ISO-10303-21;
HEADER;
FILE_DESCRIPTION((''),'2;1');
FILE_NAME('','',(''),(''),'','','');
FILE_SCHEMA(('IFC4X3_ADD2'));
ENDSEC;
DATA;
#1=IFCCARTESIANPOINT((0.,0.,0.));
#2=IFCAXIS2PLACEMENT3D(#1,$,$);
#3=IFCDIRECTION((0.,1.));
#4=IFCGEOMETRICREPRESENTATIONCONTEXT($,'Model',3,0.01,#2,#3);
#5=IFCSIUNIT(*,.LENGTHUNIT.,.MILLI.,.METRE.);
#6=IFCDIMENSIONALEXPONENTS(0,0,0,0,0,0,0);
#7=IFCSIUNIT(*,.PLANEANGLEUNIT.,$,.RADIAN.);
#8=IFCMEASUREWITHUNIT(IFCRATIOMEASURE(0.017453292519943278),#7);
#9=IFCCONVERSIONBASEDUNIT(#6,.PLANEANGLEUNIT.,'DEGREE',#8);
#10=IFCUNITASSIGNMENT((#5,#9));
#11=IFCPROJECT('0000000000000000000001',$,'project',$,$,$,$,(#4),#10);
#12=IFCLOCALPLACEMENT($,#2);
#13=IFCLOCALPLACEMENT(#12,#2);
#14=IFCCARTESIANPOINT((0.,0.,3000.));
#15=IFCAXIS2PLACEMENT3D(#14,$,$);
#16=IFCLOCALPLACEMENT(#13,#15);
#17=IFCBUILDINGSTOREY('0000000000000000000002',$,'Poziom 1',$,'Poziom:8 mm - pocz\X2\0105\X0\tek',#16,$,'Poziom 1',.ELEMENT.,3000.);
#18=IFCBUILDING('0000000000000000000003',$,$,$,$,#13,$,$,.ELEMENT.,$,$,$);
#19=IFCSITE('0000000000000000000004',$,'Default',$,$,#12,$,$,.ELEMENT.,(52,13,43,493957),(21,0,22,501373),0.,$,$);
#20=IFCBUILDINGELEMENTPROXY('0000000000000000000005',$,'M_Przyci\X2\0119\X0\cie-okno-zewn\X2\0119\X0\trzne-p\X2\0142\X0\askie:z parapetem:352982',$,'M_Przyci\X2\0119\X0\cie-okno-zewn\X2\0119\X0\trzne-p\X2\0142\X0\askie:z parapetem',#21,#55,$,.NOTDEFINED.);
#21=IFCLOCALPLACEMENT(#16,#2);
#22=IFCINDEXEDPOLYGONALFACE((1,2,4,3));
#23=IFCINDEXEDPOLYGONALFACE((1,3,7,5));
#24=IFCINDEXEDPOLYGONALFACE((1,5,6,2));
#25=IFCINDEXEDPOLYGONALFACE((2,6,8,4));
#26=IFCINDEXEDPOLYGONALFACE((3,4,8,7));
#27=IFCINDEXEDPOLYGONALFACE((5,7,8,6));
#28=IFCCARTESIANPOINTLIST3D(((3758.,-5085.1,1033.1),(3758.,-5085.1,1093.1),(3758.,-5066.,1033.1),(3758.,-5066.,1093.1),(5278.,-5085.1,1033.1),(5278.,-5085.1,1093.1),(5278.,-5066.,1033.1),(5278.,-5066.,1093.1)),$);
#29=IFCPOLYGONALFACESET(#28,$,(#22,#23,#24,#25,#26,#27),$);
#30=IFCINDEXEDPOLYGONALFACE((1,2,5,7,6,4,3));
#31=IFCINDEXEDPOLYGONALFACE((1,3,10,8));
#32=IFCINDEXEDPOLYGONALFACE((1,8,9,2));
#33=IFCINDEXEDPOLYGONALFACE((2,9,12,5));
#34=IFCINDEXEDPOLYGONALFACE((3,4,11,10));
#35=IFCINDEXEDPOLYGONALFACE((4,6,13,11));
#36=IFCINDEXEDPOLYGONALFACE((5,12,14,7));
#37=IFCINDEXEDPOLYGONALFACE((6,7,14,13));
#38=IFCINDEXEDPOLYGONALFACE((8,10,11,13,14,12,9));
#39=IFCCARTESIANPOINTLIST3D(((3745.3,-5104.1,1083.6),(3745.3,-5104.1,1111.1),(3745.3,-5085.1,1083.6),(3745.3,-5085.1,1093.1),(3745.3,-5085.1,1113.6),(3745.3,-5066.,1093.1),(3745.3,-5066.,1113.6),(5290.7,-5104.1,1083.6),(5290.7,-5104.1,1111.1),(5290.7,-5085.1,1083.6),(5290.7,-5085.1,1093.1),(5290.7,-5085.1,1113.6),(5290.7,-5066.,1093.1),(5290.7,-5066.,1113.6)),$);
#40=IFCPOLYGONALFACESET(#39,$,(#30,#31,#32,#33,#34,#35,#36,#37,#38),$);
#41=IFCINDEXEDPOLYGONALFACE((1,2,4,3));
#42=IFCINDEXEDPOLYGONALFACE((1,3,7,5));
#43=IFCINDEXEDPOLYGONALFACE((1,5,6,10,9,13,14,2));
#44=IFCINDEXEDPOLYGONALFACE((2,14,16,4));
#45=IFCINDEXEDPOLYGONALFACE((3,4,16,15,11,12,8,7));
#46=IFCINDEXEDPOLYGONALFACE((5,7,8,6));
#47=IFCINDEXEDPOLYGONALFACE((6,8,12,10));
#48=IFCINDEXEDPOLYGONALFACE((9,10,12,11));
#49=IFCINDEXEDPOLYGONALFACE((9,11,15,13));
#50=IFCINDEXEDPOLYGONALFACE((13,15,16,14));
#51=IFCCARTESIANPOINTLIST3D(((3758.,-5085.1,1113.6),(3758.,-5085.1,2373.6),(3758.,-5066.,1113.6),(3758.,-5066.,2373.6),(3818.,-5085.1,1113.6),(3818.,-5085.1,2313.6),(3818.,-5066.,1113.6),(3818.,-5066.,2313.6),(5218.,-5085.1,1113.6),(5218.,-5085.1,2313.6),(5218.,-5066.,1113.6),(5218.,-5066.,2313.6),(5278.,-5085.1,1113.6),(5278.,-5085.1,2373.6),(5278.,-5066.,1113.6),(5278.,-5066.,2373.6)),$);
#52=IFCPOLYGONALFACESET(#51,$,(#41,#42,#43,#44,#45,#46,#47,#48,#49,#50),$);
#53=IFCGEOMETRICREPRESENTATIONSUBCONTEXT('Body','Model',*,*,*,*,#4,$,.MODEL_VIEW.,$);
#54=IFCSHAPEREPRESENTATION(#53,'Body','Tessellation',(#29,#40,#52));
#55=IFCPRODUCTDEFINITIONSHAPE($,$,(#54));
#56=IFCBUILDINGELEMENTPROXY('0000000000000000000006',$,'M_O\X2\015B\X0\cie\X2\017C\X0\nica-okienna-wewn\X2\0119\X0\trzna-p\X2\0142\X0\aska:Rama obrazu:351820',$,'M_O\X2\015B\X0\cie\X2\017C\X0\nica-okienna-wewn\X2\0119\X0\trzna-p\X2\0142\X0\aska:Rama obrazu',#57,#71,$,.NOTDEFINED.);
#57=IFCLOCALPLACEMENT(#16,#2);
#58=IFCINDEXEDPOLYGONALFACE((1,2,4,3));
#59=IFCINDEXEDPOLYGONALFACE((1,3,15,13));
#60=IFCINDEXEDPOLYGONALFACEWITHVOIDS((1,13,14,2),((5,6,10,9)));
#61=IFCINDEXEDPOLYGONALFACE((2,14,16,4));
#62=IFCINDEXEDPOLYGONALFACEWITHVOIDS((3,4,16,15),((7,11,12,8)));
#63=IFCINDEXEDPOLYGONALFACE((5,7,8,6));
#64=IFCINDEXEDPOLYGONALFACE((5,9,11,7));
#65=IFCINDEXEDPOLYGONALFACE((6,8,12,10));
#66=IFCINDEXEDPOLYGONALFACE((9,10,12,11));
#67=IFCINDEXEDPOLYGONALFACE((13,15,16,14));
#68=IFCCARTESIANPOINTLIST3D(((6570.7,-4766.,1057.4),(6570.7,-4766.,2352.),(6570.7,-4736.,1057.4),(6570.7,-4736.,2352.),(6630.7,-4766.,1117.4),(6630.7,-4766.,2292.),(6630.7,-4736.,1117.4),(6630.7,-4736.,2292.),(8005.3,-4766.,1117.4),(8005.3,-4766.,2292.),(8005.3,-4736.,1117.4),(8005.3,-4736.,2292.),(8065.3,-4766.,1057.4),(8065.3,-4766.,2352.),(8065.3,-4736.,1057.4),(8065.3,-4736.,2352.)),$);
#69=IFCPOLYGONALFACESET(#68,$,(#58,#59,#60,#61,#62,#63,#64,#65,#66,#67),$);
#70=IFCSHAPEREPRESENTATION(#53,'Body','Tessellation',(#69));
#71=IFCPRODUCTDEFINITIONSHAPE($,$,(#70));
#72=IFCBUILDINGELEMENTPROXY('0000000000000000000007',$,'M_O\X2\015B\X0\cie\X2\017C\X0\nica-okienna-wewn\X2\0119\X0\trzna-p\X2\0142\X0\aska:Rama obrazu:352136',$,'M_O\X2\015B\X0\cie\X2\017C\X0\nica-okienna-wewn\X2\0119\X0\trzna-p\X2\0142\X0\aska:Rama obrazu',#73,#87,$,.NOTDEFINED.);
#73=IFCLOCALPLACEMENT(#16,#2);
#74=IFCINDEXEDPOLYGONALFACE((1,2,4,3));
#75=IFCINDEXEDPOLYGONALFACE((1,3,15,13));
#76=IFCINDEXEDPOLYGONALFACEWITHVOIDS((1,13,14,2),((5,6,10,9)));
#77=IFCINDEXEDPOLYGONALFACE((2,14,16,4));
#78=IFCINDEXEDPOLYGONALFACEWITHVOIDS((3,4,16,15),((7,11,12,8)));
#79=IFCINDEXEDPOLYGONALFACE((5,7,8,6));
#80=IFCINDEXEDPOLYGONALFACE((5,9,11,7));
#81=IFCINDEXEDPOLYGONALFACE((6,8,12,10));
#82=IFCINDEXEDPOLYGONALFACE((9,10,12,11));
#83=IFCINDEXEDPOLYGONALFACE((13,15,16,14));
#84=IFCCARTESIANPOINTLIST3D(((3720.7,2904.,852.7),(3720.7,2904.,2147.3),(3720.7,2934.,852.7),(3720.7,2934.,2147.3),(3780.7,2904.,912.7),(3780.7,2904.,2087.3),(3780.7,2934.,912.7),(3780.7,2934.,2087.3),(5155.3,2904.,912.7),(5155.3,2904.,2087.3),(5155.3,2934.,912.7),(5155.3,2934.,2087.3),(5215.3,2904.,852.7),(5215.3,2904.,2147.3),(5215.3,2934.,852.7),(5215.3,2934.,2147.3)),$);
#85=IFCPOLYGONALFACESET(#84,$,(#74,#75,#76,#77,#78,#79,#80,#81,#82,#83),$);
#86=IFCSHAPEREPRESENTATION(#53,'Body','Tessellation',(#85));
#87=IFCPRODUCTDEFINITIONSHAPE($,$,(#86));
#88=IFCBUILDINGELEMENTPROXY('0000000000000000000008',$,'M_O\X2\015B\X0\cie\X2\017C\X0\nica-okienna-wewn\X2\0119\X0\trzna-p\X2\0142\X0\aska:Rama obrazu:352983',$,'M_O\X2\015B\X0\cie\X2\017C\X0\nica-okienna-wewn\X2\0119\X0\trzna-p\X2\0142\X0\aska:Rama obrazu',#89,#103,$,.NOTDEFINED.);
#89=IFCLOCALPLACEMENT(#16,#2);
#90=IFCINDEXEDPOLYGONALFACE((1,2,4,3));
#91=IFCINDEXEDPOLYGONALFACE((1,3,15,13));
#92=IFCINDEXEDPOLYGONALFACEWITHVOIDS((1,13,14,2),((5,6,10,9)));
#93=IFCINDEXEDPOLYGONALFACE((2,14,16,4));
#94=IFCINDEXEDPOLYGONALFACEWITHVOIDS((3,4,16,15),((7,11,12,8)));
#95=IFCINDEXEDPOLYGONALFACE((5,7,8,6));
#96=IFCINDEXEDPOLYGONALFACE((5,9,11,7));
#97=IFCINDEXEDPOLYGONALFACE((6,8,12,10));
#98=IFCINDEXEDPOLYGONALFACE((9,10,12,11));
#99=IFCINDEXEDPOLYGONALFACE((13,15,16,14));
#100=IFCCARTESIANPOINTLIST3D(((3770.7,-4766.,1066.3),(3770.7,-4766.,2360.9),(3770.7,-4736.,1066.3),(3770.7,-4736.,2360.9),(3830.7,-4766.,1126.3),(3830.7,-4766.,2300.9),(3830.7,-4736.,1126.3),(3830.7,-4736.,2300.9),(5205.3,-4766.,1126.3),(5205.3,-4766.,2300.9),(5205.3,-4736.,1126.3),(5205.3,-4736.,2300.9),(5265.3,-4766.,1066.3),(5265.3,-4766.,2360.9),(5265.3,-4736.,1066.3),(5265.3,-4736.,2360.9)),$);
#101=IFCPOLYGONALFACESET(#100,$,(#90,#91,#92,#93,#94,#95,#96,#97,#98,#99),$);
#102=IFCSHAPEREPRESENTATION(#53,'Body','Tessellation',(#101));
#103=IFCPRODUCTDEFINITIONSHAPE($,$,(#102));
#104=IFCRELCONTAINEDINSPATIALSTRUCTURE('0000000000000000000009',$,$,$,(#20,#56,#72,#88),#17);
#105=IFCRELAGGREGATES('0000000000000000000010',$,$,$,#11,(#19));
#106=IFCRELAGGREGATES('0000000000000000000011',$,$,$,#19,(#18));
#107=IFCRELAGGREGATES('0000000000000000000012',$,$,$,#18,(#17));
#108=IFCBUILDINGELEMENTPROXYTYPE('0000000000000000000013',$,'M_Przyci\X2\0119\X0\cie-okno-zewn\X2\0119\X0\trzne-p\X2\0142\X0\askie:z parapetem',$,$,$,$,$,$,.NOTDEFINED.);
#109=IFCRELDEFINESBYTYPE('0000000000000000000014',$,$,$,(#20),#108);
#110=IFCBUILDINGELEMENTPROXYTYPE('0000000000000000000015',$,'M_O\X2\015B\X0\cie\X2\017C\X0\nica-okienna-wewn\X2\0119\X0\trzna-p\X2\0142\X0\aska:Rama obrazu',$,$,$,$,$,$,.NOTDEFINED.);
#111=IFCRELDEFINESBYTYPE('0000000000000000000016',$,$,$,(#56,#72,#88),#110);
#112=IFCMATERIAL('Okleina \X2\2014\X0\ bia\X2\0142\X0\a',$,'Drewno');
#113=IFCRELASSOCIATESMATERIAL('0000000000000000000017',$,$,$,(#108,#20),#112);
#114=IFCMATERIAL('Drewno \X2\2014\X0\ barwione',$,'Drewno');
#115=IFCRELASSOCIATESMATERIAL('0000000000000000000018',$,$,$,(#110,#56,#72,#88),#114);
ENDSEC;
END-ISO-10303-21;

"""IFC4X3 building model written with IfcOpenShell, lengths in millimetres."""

from ifc_helpers import new_model, entity, si_unit, converted_unit, direction, frame, frame_2d, origin, place, context, subcontext, project, spatial, polyline, rectangle, outline, extrude, source, transform, mapped, material, type_object, type_shapes, element, save


model = new_model("IFC4X3")

# Units and contexts
model_context = context("Model", 3, precision=0.01, world=origin(), true_north=direction((0.0, 1.0)))
body_context = subcontext(model_context, "Body", "Model", "MODEL_VIEW")
ifc_project = project(units=[si_unit("LENGTHUNIT", "METRE", prefix="MILLI"), converted_unit("PLANEANGLEUNIT", "DEGREE", entity("IfcRatioMeasure", 0.017453292519943278), si_unit("PLANEANGLEUNIT", "RADIAN"), dimensions=[0, 0, 0, 0, 0, 0, 0])], contexts=[model_context])

# Site, building, storey
site_placement = place(None, origin())
site = spatial("IfcSite", under=ifc_project, at=site_placement, Name="Default", CompositionType="ELEMENT", RefLatitude=(52, 13, 43, 493957), RefLongitude=(21, 0, 22, 501373), RefElevation=0.0)
building_placement = place(site_placement, origin())
building = spatial("IfcBuilding", under=site, at=building_placement, CompositionType="ELEMENT")
storey_placement = place(building_placement, frame((0.0, 0.0, 3000.0)))
storey = spatial("IfcBuildingStorey", under=building, at=storey_placement, Name="Poziom 1", ObjectType="Poziom:8 mm - początek", LongName="Poziom 1", CompositionType="ELEMENT", Elevation=3000.0)

# Building element proxies
ifc_material_1 = material(Name="Okleina — biała", Category="Drewno")
ifc_material_2 = material(Name="Drewno — barwione", Category="Drewno")
building_element_proxy_type_1 = type_object("IfcBuildingElementProxyType", Name="M_Przycięcie-okno-zewnętrzne-płaskie:z parapetem", PredefinedType="NOTDEFINED", material=ifc_material_1)
shared_shape_1 = source(origin(), body_context, "Body", "SweptSolid", [
    extrude(rectangle(XDim=1520.0, YDim=60.0, at=frame_2d((0.0, 0.0), x_axis=(1.0, 0.0))), frame((0.0, -1250.4, 0.0), z_axis=(0.0, 0.0, 1.0), x_axis=(-1.0, 0.0, 0.0)), (0.0, 0.0, 1.0), 19.0),
    extrude(outline(polyline([(-19.0, -15.2), (0.0, -15.2), (0.0, -5.7), (19.0, -5.7), (19.0, 14.8), (0.0, 14.8), (-19.0, 12.3), (-19.0, -15.2)])), frame((-772.7, -1214.8, 19.0), z_axis=(1.0, 0.0, 0.0), x_axis=(0.0, 0.0, -1.0)), (0.0, 0.0, 1.0), 1545.4),
    extrude(outline(polyline([(-645.0, -760.0), (615.0, -760.0), (615.0, -700.0), (-585.0, -700.0), (-585.0, 700.0), (615.0, 700.0), (615.0, 760.0), (-645.0, 760.0), (-645.0, -760.0)])), frame((0.0, -585.0, 0.0), z_axis=(0.0, 0.0, 1.0), x_axis=(0.0, -1.0, 0.0)), (0.0, 0.0, 1.0), 19.0),
])
type_shapes(building_element_proxy_type_1, [shared_shape_1])
for number, where, z_axis, x_axis, name in (
    (1, (4518.0, -5066.0, 2313.6), (0.0, -1.0, 0.0), (1.0, 0.0, 0.0), "M_Przycięcie-okno-zewnętrzne-płaskie:z parapetem:352982"),
):
    element("IfcBuildingElementProxy", number, at=place(storey_placement, frame(where, z_axis=z_axis, x_axis=x_axis)), inside=storey, type_object=building_element_proxy_type_1, material=ifc_material_1, Name=name, ObjectType="M_Przycięcie-okno-zewnętrzne-płaskie:z parapetem", PredefinedType="NOTDEFINED", context=body_context, shape_type="MappedRepresentation", body=[
        mapped(shared_shape_1, transform((0.0, 0.0, 0.0), scale=1.0)),
    ])
building_element_proxy_type_2 = type_object("IfcBuildingElementProxyType", Name="M_Ościeżnica-okienna-wewnętrzna-płaska:Rama obrazu", PredefinedType="NOTDEFINED", material=ifc_material_2)
shared_shape_2 = source(origin(), body_context, "Body", "SweptSolid", [
    extrude(outline(polyline([(-747.3, -647.3), (747.3, -647.3), (747.3, 647.3), (-747.3, 647.3), (-747.3, -647.3)]), holes=[polyline([(-687.3, -587.3), (-687.3, 587.3), (687.3, 587.3), (687.3, -587.3), (-687.3, -587.3)])]), frame((0.0, -600.0, 0.0), z_axis=(0.0, 0.0, 1.0), x_axis=(-1.0, 0.0, 0.0)), (0.0, 0.0, 1.0), 30.0),
])
type_shapes(building_element_proxy_type_2, [shared_shape_2])
for number, where, z_axis, x_axis, name in (
    (2, (7318.0, -4766.0, 2304.7), (0.0, 1.0, 0.0), (-1.0, 0.0, 0.0), "M_Ościeżnica-okienna-wewnętrzna-płaska:Rama obrazu:351820"),
    (3, (4468.0, 2934.0, 2100.0), (0.0, -1.0, 0.0), (1.0, 0.0, 0.0), "M_Ościeżnica-okienna-wewnętrzna-płaska:Rama obrazu:352136"),
    (4, (4518.0, -4766.0, 2313.6), (0.0, 1.0, 0.0), (-1.0, 0.0, 0.0), "M_Ościeżnica-okienna-wewnętrzna-płaska:Rama obrazu:352983"),
):
    element("IfcBuildingElementProxy", number, at=place(storey_placement, frame(where, z_axis=z_axis, x_axis=x_axis)), inside=storey, type_object=building_element_proxy_type_2, material=ifc_material_2, Name=name, ObjectType="M_Ościeżnica-okienna-wewnętrzna-płaska:Rama obrazu", PredefinedType="NOTDEFINED", context=body_context, shape_type="MappedRepresentation", body=[
        mapped(shared_shape_2, transform((0.0, 0.0, 0.0), scale=1.0)),
    ])

save(model, "model.ifc")
